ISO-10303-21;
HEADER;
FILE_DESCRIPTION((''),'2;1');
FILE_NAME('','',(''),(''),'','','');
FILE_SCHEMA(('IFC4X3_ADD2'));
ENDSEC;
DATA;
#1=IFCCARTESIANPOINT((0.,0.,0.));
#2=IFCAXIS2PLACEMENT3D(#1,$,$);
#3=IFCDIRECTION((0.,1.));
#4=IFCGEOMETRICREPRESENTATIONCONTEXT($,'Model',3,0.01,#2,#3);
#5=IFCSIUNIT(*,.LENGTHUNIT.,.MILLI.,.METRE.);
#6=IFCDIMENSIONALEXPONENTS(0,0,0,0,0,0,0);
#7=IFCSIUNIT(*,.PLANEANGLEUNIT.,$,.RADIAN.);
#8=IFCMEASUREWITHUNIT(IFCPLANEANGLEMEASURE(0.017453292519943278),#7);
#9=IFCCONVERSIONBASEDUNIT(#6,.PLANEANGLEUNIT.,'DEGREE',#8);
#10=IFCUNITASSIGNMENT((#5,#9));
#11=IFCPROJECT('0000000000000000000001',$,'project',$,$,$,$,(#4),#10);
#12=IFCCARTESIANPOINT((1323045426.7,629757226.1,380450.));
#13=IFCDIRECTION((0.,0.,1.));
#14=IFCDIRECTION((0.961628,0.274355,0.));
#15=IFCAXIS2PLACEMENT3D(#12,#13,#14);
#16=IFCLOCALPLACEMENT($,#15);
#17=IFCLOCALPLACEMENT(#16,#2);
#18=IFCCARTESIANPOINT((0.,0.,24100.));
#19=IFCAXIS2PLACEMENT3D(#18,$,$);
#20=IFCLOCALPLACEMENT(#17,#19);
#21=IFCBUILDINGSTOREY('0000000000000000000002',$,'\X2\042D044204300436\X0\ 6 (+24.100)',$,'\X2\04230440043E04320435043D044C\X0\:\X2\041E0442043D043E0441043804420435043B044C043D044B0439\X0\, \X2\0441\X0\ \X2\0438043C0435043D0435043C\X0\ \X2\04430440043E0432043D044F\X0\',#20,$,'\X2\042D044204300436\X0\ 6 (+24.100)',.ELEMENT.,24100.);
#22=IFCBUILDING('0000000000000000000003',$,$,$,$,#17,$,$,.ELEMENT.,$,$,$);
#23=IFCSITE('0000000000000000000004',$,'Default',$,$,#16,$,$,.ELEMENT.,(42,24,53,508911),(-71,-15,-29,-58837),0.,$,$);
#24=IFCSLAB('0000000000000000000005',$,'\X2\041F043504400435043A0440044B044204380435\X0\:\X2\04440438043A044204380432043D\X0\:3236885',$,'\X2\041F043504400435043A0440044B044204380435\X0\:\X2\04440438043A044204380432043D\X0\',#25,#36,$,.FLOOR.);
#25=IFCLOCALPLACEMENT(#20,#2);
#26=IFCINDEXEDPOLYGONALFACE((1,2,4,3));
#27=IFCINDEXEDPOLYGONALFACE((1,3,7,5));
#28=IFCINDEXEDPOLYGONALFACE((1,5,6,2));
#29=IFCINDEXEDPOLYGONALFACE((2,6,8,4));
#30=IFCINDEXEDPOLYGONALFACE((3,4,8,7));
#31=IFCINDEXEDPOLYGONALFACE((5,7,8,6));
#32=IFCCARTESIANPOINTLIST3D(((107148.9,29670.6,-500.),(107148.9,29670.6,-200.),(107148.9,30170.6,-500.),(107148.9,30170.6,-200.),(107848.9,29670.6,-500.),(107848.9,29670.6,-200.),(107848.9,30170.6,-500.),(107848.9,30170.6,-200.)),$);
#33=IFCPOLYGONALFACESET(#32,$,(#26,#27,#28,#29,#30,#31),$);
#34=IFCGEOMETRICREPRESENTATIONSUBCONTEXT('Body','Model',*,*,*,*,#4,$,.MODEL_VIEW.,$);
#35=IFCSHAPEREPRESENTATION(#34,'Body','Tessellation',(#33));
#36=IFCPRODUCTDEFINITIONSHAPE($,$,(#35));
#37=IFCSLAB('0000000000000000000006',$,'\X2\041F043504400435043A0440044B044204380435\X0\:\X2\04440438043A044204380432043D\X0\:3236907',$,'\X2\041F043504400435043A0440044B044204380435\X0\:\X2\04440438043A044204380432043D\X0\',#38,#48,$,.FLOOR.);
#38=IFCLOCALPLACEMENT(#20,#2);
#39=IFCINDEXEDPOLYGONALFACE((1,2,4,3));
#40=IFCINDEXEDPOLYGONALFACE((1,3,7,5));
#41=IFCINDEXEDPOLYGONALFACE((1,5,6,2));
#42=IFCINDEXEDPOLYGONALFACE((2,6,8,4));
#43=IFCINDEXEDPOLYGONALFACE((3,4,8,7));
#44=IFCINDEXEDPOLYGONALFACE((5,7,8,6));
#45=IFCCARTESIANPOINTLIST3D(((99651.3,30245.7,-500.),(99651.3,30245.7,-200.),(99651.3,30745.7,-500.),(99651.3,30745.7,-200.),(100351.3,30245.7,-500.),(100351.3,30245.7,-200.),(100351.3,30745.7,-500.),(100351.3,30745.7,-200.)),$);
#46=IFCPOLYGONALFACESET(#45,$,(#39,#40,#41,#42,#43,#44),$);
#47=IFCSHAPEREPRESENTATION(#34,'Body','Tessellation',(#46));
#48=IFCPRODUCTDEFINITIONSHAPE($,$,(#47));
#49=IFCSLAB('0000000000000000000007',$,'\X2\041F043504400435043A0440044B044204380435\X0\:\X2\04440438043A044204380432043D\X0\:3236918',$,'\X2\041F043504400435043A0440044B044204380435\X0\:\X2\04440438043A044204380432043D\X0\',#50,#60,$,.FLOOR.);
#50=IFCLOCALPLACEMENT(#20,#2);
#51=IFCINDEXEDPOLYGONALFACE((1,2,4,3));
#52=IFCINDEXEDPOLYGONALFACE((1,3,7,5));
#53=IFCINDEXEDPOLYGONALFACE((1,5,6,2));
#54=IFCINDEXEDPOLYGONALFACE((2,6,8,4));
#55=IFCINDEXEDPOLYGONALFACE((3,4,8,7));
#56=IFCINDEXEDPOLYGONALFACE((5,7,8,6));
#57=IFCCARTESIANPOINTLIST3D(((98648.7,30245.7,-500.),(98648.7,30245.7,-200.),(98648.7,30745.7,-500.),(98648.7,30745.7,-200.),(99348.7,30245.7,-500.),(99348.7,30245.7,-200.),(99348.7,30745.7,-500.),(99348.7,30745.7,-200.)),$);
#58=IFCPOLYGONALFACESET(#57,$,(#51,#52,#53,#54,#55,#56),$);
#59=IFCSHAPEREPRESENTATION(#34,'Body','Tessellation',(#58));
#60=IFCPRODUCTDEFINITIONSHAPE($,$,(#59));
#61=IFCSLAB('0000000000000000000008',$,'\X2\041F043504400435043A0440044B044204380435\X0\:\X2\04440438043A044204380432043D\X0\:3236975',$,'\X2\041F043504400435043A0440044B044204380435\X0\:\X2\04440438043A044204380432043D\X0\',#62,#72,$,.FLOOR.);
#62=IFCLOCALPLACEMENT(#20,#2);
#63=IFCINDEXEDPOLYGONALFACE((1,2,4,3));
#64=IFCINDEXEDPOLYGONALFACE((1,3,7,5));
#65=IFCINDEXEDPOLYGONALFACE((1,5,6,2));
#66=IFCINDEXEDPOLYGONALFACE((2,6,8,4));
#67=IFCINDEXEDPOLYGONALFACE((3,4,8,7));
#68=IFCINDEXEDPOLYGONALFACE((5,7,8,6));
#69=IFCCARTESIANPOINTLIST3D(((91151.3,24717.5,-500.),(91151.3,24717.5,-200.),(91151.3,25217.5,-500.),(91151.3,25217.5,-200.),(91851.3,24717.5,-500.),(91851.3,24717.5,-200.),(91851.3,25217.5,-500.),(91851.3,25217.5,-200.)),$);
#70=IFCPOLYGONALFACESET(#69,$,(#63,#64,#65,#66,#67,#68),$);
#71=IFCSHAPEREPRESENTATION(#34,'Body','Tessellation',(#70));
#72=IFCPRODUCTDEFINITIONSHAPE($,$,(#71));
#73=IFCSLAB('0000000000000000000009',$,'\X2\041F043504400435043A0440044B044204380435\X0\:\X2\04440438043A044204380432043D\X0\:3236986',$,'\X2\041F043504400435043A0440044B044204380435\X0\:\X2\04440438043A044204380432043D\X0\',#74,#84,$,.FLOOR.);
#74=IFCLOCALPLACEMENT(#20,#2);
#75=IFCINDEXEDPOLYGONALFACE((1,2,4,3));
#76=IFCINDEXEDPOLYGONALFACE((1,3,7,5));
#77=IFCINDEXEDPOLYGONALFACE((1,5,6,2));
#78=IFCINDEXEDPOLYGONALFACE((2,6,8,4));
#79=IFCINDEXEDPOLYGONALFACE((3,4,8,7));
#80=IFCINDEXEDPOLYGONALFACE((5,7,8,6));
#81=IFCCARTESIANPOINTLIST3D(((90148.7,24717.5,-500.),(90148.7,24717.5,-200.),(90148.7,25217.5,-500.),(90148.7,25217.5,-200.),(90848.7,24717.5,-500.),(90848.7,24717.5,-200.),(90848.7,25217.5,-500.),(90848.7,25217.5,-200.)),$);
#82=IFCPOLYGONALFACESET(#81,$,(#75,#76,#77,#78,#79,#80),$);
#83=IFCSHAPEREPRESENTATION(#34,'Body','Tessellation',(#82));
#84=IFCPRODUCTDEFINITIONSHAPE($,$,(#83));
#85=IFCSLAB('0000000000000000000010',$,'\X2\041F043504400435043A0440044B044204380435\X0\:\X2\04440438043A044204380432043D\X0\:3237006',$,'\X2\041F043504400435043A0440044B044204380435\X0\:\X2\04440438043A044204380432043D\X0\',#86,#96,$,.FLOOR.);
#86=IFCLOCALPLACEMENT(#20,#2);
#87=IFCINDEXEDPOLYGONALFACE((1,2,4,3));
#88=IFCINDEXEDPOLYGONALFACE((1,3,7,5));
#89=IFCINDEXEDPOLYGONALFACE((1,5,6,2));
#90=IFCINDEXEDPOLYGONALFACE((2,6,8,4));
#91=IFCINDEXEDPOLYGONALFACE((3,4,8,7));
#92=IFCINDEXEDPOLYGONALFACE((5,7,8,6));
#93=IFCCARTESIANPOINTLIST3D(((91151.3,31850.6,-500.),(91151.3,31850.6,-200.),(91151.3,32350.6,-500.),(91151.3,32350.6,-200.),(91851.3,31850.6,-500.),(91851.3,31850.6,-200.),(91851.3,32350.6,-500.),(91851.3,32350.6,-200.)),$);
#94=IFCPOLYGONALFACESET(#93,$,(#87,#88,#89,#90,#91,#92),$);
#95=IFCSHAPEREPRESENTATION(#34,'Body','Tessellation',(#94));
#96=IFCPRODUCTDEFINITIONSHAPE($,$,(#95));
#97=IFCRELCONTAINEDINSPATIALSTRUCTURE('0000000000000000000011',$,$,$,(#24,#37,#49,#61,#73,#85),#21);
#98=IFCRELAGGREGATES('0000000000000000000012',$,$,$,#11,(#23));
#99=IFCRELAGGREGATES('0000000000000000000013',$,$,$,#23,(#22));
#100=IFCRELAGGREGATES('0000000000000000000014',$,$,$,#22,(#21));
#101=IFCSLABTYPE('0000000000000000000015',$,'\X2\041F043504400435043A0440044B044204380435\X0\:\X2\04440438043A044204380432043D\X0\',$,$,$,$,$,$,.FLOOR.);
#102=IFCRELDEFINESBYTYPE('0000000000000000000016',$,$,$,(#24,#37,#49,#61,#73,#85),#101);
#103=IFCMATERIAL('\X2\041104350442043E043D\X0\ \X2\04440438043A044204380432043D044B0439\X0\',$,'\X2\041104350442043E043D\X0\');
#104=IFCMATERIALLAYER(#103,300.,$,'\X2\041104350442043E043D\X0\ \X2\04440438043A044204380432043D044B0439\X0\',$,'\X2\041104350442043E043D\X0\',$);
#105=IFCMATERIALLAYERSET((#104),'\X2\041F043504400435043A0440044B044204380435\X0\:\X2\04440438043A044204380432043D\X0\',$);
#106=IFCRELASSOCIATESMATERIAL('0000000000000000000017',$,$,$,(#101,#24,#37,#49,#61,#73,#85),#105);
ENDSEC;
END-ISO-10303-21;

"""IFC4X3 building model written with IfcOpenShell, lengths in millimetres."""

from ifc_helpers import new_model, entity, si_unit, converted_unit, direction, frame, frame_2d, origin, place, context, subcontext, project, spatial, rectangle, extrude, material, layer, layer_set, layer_usage, type_object, element, save


model = new_model("IFC4X3")

# Units and contexts
model_context = context("Model", 3, precision=0.01, world=origin(), true_north=direction((0.0, 1.0)))
body_context = subcontext(model_context, "Body", "Model", "MODEL_VIEW")
ifc_project = project(units=[si_unit("LENGTHUNIT", "METRE", prefix="MILLI"), converted_unit("PLANEANGLEUNIT", "DEGREE", entity("IfcPlaneAngleMeasure", 0.017453292519943278), si_unit("PLANEANGLEUNIT", "RADIAN"), dimensions=[0, 0, 0, 0, 0, 0, 0])], contexts=[model_context])

# Site, building, storey
site_placement = place(None, frame((1323045426.7, 629757226.1, 380450.0), z_axis=(0.0, 0.0, 1.0), x_axis=(0.961628, 0.274355, 0.0)))
site = spatial("IfcSite", under=ifc_project, at=site_placement, Name="Default", CompositionType="ELEMENT", RefLatitude=(42, 24, 53, 508911), RefLongitude=(-71, -15, -29, -58837), RefElevation=0.0)
building_placement = place(site_placement, origin())
building = spatial("IfcBuilding", under=site, at=building_placement, CompositionType="ELEMENT")
storey_placement = place(building_placement, frame((0.0, 0.0, 24100.0)))
storey = spatial("IfcBuildingStorey", under=building, at=storey_placement, Name="Этаж 6 (+24.100)", ObjectType="Уровень:Относительный, с именем уровня", LongName="Этаж 6 (+24.100)", CompositionType="ELEMENT", Elevation=24100.0)

# Slabs
ifc_material_1 = material(Name="Бетон фиктивный", Category="Бетон")
ifc_layer_1 = layer(ifc_material_1, 300.0, Name="Бетон фиктивный", Category="Бетон")
ifc_layer_set_1 = layer_set([ifc_layer_1], Name="Перекрытие:фиктивн")
slab_type_1 = type_object("IfcSlabType", Name="Перекрытие:фиктивн", PredefinedType="FLOOR", material=ifc_layer_set_1)
ifc_layer_usage_1 = layer_usage(ifc_layer_set_1, "AXIS3", "POSITIVE", 0.0)
slab_1_placement = place(storey_placement, origin())
element("IfcSlab", 1, at=slab_1_placement, inside=storey, type_object=slab_type_1, material=ifc_layer_usage_1, Name="Перекрытие:фиктивн:3236885", ObjectType="Перекрытие:фиктивн", PredefinedType="FLOOR", context=body_context, shape_type="SweptSolid", body=[
    extrude(rectangle(XDim=500.0, YDim=700.0, at=frame_2d((0.0, 0.0), x_axis=(1.0, 0.0))), frame((107498.9, 29920.6, -200.0), z_axis=(0.0, 0.0, -1.0), x_axis=(0.0, 1.0, 0.0)), (0.0, 0.0, 1.0), 300.0),
])
ifc_layer_usage_2 = layer_usage(ifc_layer_set_1, "AXIS3", "POSITIVE", 0.0)
slab_2_placement = place(storey_placement, origin())
element("IfcSlab", 2, at=slab_2_placement, inside=storey, type_object=slab_type_1, material=ifc_layer_usage_2, Name="Перекрытие:фиктивн:3236907", ObjectType="Перекрытие:фиктивн", PredefinedType="FLOOR", context=body_context, shape_type="SweptSolid", body=[
    extrude(rectangle(XDim=500.0, YDim=700.0, at=frame_2d((0.0, 0.0), x_axis=(1.0, 0.0))), frame((100001.3, 30495.7, -200.0), z_axis=(0.0, 0.0, -1.0), x_axis=(0.0, 1.0, 0.0)), (0.0, 0.0, 1.0), 300.0),
])
ifc_layer_usage_3 = layer_usage(ifc_layer_set_1, "AXIS3", "POSITIVE", 0.0)
slab_3_placement = place(storey_placement, origin())
element("IfcSlab", 3, at=slab_3_placement, inside=storey, type_object=slab_type_1, material=ifc_layer_usage_3, Name="Перекрытие:фиктивн:3236918", ObjectType="Перекрытие:фиктивн", PredefinedType="FLOOR", context=body_context, shape_type="SweptSolid", body=[
    extrude(rectangle(XDim=500.0, YDim=700.0, at=frame_2d((0.0, 0.0), x_axis=(1.0, 0.0))), frame((98998.7, 30495.7, -200.0), z_axis=(0.0, 0.0, -1.0), x_axis=(0.0, 1.0, 0.0)), (0.0, 0.0, 1.0), 300.0),
])
ifc_layer_usage_4 = layer_usage(ifc_layer_set_1, "AXIS3", "POSITIVE", 0.0)
slab_4_placement = place(storey_placement, origin())
element("IfcSlab", 4, at=slab_4_placement, inside=storey, type_object=slab_type_1, material=ifc_layer_usage_4, Name="Перекрытие:фиктивн:3236975", ObjectType="Перекрытие:фиктивн", PredefinedType="FLOOR", context=body_context, shape_type="SweptSolid", body=[
    extrude(rectangle(XDim=500.0, YDim=700.0, at=frame_2d((0.0, 0.0), x_axis=(1.0, 0.0))), frame((91501.3, 24967.5, -200.0), z_axis=(0.0, 0.0, -1.0), x_axis=(0.0, 1.0, 0.0)), (0.0, 0.0, 1.0), 300.0),
])
ifc_layer_usage_5 = layer_usage(ifc_layer_set_1, "AXIS3", "POSITIVE", 0.0)
slab_5_placement = place(storey_placement, origin())
element("IfcSlab", 5, at=slab_5_placement, inside=storey, type_object=slab_type_1, material=ifc_layer_usage_5, Name="Перекрытие:фиктивн:3236986", ObjectType="Перекрытие:фиктивн", PredefinedType="FLOOR", context=body_context, shape_type="SweptSolid", body=[
    extrude(rectangle(XDim=500.0, YDim=700.0, at=frame_2d((0.0, 0.0), x_axis=(1.0, 0.0))), frame((90498.7, 24967.5, -200.0), z_axis=(0.0, 0.0, -1.0), x_axis=(0.0, 1.0, 0.0)), (0.0, 0.0, 1.0), 300.0),
])
ifc_layer_usage_6 = layer_usage(ifc_layer_set_1, "AXIS3", "POSITIVE", 0.0)
slab_6_placement = place(storey_placement, origin())
element("IfcSlab", 6, at=slab_6_placement, inside=storey, type_object=slab_type_1, material=ifc_layer_usage_6, Name="Перекрытие:фиктивн:3237006", ObjectType="Перекрытие:фиктивн", PredefinedType="FLOOR", context=body_context, shape_type="SweptSolid", body=[
    extrude(rectangle(XDim=500.0, YDim=700.0, at=frame_2d((0.0, 0.0), x_axis=(1.0, 0.0))), frame((91501.3, 32100.6, -200.0), z_axis=(0.0, 0.0, -1.0), x_axis=(0.0, 1.0, 0.0)), (0.0, 0.0, 1.0), 300.0),
])

save(model, "model.ifc")
